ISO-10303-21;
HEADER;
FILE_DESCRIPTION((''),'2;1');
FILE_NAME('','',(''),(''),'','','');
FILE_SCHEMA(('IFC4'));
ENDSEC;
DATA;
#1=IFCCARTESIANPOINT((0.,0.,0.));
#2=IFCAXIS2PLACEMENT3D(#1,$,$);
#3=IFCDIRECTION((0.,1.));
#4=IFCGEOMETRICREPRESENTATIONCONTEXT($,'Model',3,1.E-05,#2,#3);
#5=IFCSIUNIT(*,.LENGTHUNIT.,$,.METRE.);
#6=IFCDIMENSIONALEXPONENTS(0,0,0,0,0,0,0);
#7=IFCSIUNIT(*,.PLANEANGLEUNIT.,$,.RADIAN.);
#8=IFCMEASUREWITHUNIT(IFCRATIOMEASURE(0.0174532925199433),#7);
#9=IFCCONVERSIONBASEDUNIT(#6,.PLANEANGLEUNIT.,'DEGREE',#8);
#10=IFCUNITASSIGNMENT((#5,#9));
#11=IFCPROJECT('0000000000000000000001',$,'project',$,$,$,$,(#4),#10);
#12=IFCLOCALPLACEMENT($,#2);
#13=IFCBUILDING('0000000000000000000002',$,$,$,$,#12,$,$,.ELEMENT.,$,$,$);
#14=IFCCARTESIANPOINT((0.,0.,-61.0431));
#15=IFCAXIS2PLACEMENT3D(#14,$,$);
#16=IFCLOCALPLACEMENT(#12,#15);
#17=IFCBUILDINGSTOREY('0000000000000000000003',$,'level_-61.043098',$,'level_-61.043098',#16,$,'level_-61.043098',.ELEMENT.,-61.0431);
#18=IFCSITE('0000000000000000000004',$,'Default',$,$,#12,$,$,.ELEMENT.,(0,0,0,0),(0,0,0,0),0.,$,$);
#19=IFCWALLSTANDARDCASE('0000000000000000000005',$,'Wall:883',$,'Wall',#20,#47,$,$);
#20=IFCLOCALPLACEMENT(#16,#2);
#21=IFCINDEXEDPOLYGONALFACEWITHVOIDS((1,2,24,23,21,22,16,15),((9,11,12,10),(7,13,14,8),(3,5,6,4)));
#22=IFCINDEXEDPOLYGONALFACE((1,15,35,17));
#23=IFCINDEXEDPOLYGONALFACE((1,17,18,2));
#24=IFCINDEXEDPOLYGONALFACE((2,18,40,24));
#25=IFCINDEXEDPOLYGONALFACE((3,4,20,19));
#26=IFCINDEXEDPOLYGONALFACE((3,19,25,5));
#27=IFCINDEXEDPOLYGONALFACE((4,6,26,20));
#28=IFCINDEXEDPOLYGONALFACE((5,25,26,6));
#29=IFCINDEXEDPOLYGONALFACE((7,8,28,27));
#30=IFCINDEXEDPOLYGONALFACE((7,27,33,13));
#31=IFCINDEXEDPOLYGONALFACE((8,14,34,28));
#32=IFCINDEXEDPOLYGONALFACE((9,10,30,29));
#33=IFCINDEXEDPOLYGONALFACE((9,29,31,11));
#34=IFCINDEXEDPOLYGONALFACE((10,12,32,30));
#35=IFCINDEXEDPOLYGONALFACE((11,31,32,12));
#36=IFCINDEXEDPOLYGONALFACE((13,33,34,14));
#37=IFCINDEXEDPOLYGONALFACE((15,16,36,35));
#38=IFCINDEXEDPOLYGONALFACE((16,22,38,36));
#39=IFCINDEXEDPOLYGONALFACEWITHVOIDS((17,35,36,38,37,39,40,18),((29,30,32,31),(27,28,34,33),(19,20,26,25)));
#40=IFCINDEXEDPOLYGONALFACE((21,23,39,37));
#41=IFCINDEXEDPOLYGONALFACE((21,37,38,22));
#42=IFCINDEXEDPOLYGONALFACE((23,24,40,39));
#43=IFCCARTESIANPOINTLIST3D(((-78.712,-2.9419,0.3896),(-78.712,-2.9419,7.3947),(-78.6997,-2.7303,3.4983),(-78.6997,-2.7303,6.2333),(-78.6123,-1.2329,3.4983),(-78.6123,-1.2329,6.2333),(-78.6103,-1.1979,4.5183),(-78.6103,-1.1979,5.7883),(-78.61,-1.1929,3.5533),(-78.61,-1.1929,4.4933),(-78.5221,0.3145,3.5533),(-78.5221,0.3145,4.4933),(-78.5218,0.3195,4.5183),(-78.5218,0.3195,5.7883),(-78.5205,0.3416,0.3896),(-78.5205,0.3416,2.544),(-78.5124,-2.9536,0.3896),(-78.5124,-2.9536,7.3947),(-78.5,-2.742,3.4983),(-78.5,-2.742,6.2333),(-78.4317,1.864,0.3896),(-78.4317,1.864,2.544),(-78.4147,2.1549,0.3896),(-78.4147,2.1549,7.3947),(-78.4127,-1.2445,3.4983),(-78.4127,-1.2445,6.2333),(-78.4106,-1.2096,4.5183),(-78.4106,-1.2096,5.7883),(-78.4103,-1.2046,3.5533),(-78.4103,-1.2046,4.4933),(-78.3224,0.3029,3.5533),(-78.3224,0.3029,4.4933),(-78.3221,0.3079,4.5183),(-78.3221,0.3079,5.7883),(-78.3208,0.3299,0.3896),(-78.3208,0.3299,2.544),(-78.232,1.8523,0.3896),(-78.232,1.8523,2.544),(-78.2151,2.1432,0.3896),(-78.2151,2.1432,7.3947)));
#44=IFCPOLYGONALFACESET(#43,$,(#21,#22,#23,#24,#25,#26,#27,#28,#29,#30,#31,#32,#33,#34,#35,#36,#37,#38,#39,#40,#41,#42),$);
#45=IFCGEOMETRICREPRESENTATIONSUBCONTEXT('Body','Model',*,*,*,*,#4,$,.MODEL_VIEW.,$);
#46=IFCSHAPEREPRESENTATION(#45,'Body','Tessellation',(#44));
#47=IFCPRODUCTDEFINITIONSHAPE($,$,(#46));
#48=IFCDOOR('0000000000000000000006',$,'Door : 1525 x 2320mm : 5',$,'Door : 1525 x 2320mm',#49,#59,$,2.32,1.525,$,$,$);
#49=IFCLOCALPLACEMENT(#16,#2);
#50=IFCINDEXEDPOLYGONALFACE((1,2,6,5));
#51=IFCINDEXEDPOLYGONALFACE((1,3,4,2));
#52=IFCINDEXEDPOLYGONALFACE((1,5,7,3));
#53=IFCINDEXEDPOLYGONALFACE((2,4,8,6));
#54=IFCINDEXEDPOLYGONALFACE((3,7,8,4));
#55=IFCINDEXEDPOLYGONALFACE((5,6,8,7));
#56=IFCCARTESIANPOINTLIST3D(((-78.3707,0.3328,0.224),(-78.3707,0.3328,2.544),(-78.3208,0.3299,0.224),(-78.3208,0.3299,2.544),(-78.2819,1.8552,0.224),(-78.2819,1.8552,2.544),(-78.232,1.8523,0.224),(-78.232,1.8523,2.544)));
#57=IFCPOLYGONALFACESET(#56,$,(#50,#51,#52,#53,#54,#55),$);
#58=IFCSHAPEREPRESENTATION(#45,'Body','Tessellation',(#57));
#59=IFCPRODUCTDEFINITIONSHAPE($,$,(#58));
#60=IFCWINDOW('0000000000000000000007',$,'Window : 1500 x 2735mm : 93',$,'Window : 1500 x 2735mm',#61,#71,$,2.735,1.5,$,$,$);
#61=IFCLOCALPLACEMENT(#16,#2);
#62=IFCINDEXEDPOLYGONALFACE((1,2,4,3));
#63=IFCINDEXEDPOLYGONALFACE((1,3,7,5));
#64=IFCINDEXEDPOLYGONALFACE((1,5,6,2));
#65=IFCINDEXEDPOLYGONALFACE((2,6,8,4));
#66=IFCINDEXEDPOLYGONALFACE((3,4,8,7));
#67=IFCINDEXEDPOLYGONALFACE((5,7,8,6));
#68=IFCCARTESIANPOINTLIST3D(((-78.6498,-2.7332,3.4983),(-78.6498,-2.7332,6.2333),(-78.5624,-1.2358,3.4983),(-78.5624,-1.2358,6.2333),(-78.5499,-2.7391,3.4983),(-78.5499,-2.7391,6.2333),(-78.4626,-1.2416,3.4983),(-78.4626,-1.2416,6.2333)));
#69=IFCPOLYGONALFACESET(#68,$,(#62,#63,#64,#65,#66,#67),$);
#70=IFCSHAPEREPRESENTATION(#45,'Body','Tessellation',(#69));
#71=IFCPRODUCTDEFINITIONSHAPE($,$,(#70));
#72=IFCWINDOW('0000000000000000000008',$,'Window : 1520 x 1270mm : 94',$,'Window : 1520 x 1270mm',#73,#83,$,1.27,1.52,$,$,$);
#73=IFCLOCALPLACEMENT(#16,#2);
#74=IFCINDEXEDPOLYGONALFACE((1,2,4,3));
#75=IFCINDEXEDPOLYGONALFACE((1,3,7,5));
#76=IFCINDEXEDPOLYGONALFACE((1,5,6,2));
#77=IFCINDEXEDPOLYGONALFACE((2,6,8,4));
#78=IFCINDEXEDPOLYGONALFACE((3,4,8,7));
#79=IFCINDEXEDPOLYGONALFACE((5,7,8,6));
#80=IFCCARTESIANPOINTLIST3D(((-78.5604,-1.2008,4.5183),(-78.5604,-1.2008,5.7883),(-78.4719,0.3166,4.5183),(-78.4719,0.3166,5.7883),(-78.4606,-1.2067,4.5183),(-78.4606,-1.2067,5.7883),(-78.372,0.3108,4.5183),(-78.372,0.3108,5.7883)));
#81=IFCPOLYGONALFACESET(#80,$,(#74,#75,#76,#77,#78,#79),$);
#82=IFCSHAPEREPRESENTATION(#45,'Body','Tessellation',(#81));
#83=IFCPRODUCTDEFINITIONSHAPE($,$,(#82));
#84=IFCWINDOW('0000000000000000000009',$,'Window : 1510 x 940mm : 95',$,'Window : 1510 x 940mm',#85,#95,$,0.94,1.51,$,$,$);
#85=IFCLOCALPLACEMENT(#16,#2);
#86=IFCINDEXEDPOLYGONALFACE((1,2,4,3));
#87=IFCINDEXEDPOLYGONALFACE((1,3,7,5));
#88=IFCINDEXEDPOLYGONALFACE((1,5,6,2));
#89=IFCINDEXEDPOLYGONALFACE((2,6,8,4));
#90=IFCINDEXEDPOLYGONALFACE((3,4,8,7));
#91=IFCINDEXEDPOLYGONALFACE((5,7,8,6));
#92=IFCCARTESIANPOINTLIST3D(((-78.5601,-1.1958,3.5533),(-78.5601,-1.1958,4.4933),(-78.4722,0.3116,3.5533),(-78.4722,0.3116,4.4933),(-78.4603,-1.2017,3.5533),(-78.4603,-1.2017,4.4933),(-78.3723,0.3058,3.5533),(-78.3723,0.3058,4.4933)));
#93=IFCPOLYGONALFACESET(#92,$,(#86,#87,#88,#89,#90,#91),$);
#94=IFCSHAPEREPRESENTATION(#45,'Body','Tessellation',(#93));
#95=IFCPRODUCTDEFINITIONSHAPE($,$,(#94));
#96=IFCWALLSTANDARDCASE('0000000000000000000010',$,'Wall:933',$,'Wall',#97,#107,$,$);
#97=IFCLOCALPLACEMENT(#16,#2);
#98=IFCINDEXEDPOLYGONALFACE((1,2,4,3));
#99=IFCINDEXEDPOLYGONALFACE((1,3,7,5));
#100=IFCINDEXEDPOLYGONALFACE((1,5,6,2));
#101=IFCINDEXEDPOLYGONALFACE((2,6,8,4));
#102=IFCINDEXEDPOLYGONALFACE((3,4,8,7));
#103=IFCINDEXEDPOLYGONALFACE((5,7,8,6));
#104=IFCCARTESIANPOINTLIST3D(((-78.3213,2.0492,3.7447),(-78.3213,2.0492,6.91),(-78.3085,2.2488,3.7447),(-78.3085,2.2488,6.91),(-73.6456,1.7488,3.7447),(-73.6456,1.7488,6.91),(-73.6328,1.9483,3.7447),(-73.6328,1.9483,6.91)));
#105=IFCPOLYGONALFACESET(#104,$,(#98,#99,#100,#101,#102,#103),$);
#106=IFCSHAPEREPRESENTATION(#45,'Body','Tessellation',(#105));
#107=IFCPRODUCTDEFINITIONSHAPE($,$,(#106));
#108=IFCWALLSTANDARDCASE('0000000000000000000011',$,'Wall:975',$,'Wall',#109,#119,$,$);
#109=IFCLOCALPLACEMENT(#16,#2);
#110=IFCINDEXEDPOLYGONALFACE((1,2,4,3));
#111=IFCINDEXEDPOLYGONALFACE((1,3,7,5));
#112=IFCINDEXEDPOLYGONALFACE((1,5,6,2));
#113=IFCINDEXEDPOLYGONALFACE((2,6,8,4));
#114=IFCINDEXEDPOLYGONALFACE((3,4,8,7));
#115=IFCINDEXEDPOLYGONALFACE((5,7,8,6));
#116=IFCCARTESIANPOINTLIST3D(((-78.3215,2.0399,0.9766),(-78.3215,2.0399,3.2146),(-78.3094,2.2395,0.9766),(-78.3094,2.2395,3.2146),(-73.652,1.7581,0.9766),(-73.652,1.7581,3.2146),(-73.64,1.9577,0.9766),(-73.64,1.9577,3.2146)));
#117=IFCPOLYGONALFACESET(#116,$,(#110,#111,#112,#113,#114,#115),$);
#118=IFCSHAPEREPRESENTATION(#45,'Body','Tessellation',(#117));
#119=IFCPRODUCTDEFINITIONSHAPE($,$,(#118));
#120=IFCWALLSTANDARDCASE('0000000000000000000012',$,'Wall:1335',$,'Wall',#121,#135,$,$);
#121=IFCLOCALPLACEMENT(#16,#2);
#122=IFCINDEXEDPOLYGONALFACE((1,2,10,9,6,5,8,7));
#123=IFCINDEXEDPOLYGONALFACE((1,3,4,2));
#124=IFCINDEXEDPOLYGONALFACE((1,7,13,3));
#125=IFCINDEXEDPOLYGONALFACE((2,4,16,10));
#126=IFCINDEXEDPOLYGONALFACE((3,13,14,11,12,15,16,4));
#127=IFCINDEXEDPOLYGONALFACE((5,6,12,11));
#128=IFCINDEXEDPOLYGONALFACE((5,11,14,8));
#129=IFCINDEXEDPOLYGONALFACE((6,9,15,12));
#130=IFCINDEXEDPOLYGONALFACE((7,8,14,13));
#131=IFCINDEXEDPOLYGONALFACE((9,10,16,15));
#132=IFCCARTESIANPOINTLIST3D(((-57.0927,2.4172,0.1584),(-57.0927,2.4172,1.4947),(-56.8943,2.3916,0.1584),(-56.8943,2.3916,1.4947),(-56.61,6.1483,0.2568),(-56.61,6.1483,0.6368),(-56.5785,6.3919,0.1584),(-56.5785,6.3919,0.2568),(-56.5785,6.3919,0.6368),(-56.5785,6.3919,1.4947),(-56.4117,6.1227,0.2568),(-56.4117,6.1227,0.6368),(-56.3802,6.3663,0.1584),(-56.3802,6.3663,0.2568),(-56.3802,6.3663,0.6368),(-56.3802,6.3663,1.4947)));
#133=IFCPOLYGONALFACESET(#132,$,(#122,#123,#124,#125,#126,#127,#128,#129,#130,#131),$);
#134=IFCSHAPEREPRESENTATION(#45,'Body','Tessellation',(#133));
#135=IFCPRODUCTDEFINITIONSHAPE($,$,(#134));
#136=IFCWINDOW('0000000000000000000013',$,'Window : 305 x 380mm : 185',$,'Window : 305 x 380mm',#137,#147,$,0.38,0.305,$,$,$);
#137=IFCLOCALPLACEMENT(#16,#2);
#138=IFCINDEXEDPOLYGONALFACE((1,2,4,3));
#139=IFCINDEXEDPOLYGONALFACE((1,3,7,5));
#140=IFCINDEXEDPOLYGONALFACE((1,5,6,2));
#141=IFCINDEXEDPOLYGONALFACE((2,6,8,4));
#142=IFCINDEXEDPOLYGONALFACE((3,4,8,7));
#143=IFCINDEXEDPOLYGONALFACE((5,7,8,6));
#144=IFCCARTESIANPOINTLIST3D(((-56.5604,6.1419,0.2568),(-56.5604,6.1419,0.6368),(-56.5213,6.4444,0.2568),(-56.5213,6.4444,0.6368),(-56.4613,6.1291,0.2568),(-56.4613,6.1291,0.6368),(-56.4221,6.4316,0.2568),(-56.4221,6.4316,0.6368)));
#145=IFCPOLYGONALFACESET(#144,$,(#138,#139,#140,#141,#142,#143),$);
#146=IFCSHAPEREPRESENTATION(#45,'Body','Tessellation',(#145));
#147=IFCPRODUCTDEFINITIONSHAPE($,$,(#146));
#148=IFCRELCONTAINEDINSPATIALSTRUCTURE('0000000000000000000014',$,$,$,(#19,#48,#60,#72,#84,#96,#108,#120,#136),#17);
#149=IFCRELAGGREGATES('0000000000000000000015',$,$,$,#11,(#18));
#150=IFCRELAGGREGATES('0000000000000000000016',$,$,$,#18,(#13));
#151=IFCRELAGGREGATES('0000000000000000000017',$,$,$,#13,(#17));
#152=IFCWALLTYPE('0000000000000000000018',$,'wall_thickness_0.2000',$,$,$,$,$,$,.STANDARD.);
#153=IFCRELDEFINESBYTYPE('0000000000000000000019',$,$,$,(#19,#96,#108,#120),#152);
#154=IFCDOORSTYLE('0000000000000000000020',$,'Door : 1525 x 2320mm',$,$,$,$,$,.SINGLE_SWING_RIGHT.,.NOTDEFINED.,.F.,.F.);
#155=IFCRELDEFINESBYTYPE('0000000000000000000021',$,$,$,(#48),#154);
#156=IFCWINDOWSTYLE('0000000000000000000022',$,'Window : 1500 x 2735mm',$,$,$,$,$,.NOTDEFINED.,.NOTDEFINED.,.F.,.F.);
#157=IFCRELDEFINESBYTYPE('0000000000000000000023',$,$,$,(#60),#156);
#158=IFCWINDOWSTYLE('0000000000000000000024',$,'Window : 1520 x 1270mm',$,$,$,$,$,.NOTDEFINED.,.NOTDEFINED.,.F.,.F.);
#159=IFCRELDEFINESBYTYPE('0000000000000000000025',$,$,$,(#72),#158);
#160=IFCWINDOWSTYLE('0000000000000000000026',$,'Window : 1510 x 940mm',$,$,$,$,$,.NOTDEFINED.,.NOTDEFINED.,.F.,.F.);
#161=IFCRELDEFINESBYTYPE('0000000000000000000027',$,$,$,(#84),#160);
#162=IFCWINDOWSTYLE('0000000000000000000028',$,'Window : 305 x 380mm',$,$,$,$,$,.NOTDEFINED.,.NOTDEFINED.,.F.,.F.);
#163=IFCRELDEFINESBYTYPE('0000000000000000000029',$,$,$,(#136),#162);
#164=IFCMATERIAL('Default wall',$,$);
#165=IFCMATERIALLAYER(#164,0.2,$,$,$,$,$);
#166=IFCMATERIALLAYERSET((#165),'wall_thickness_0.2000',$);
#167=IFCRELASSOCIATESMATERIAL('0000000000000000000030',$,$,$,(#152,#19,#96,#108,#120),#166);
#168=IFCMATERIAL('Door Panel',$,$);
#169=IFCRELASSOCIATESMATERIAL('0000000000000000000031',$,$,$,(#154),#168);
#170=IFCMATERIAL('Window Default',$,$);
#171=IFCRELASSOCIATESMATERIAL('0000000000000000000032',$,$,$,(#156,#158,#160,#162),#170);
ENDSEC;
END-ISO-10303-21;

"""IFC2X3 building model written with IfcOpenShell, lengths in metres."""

from ifc_helpers import new_model, entity, si_unit, converted_unit, direction, frame, frame_2d, origin, origin_2d_with_axis, place, context, subcontext, project, spatial, polyline, rectangle, outline, extrude, source, transform, mapped, material, layer, layer_set, layer_usage, type_object, type_shapes, element, fill, save


model = new_model("IFC2X3")

# Units and contexts
model_context = context("Model", 3, precision=1e-05, world=origin(), true_north=direction((0.0, 1.0)))
body_context = subcontext(model_context, "Body", "Model", "MODEL_VIEW")
ifc_project = project(units=[si_unit("LENGTHUNIT", "METRE"), converted_unit("PLANEANGLEUNIT", "DEGREE", entity("IfcRatioMeasure", 0.0174532925199433), si_unit("PLANEANGLEUNIT", "RADIAN"), dimensions=[0, 0, 0, 0, 0, 0, 0])], contexts=[model_context])

# Site, building, storey
placement_1 = place(None, origin())
site = spatial("IfcSite", under=ifc_project, at=placement_1, Name="Default", CompositionType="ELEMENT", RefLatitude=(0, 0, 0, 0), RefLongitude=(0, 0, 0, 0), RefElevation=0.0)
building = spatial("IfcBuilding", under=site, at=placement_1, CompositionType="ELEMENT")
storey_placement = place(placement_1, frame((0.0, 0.0, -61.0431)))
storey = spatial("IfcBuildingStorey", under=building, at=storey_placement, Name="level_-61.043098", ObjectType="level_-61.043098", LongName="level_-61.043098", CompositionType="ELEMENT", Elevation=-61.0431)

# Shared definitions
ifc_material_1 = material(Name="Default wall")
ifc_layer = layer(ifc_material_1, 0.2)
ifc_layer_set = layer_set([ifc_layer], Name="wall_thickness_0.2000")
ifc_layer_usage = layer_usage(ifc_layer_set, "AXIS2", "POSITIVE", -0.1)
wall_type = type_object("IfcWallType", Name="wall_thickness_0.2000", PredefinedType="STANDARD", material=ifc_layer_set)

# Shared definitions
ifc_material_2 = material(Name="Window Default")

# Wall, openings, door, windows
placement_2 = place(placement_1, frame((0.0, 0.0, -60.6535)))
wall_1_placement = place(placement_2, frame((-78.3149, 2.149, 0.0), z_axis=(0.0, 0.0, 1.0), x_axis=(-0.058234, -0.998303, 0.0)))
wall_1 = element("IfcWallStandardCase", 1, at=wall_1_placement, inside=storey, type_object=wall_type, material=ifc_layer_usage, Name="Wall:883", ObjectType="Wall", context=body_context, shape_type="SweptSolid", body=[
    extrude(outline(polyline([(5.1054, -0.1), (5.1054, 0.1), (0.0, 0.1), (0.0, -0.1), (5.1054, -0.1)])), origin(), (0.0, 0.0, 1.0), 7.0051),
])
opening_1_placement = place(wall_1_placement, frame((0.2914, -0.1, -0.1656)))
opening_1 = element("IfcOpeningElement", 2, at=opening_1_placement, cuts=wall_1, ObjectType="Opening", context=body_context, shape_type="SweptSolid", body=[
    extrude(rectangle(XDim=1.525, YDim=2.32, at=frame_2d((1.16, 0.7625), x_axis=(0.0, 1.0))), frame((0.0, 0.0, 0.0), z_axis=(0.0, 1.0, 0.0), x_axis=(0.0, 0.0, 1.0)), (0.0, 0.0, 1.0), 0.2),
])
opening_2_placement = place(wall_1_placement, frame((3.3935, -0.1, 3.1088)))
opening_2 = element("IfcOpeningElement", 3, at=opening_2_placement, cuts=wall_1, ObjectType="Opening", context=body_context, shape_type="SweptSolid", body=[
    extrude(rectangle(XDim=1.5, YDim=2.735, at=frame_2d((1.3675, 0.75), x_axis=(0.0, 1.0))), frame((0.0, 0.0, 0.0), z_axis=(0.0, 1.0, 0.0), x_axis=(0.0, 0.0, 1.0)), (0.0, 0.0, 1.0), 0.2),
])
opening_3_placement = place(wall_1_placement, frame((1.8385, -0.1, 4.1288)))
opening_3 = element("IfcOpeningElement", 4, at=opening_3_placement, cuts=wall_1, ObjectType="Opening", context=body_context, shape_type="SweptSolid", body=[
    extrude(rectangle(XDim=1.52, YDim=1.27, at=frame_2d((0.635, 0.76), x_axis=(0.0, 1.0))), frame((0.0, 0.0, 0.0), z_axis=(0.0, 1.0, 0.0), x_axis=(0.0, 0.0, 1.0)), (0.0, 0.0, 1.0), 0.2),
])
opening_4_placement = place(wall_1_placement, frame((1.8435, -0.1, 3.1638)))
opening_4 = element("IfcOpeningElement", 5, at=opening_4_placement, cuts=wall_1, ObjectType="Opening", context=body_context, shape_type="SweptSolid", body=[
    extrude(rectangle(XDim=1.51, YDim=0.94, at=frame_2d((0.47, 0.755), x_axis=(0.0, 1.0))), frame((0.0, 0.0, 0.0), z_axis=(0.0, 1.0, 0.0), x_axis=(0.0, 0.0, 1.0)), (0.0, 0.0, 1.0), 0.2),
])
ifc_material_3 = material(Name="Door Panel")
door_style = type_object("IfcDoorStyle", Name="Door : 1525 x 2320mm", ConstructionType="NOTDEFINED", OperationType="SINGLE_SWING_RIGHT", ParameterTakesPrecedence=False, Sizeable=False, material=ifc_material_3)
shared_shape_1 = source(origin(), body_context, "Body", "SweptSolid", [
    extrude(rectangle(XDim=0.05, YDim=1.525, at=origin_2d_with_axis()), frame((0.7625, 0.175, 0.0), z_axis=(0.0, 0.0, 1.0), x_axis=(0.0, 1.0, 0.0)), (0.0, 0.0, 1.0), 2.32),
])
type_shapes(door_style, [shared_shape_1])
door_placement = place(opening_1_placement, origin())
door = element("IfcDoor", 6, at=door_placement, inside=storey, type_object=door_style, Name="Door : 1525 x 2320mm : 5", ObjectType="Door : 1525 x 2320mm", OverallHeight=2.32, OverallWidth=1.525, context=body_context, shape_type="MappedRepresentation", body=[
    mapped(shared_shape_1, transform((0.0, 0.0, 0.0), scale=1.0)),
])
fill(opening_1, door)
window_style_1 = type_object("IfcWindowStyle", Name="Window : 1500 x 2735mm", ConstructionType="NOTDEFINED", OperationType="NOTDEFINED", ParameterTakesPrecedence=False, Sizeable=False, material=ifc_material_2)
shared_shape_2 = source(origin(), body_context, "Body", "SweptSolid", [
    extrude(rectangle(XDim=0.1, YDim=1.5, at=origin_2d_with_axis()), frame((0.75, 0.1, 0.0), z_axis=(0.0, 0.0, 1.0), x_axis=(0.0, 1.0, 0.0)), (0.0, 0.0, 1.0), 2.735),
])
type_shapes(window_style_1, [shared_shape_2])
window_1_placement = place(opening_2_placement, origin())
window_1 = element("IfcWindow", 7, at=window_1_placement, inside=storey, type_object=window_style_1, Name="Window : 1500 x 2735mm : 93", ObjectType="Window : 1500 x 2735mm", OverallHeight=2.735, OverallWidth=1.5, context=body_context, shape_type="MappedRepresentation", body=[
    mapped(shared_shape_2, transform((0.0, 0.0, 0.0), scale=1.0)),
])
fill(opening_2, window_1)
window_style_2 = type_object("IfcWindowStyle", Name="Window : 1520 x 1270mm", ConstructionType="NOTDEFINED", OperationType="NOTDEFINED", ParameterTakesPrecedence=False, Sizeable=False, material=ifc_material_2)
shared_shape_3 = source(origin(), body_context, "Body", "SweptSolid", [
    extrude(rectangle(XDim=0.1, YDim=1.52, at=origin_2d_with_axis()), frame((0.76, 0.1, 0.0), z_axis=(0.0, 0.0, 1.0), x_axis=(0.0, 1.0, 0.0)), (0.0, 0.0, 1.0), 1.27),
])
type_shapes(window_style_2, [shared_shape_3])
window_2_placement = place(opening_3_placement, origin())
window_2 = element("IfcWindow", 8, at=window_2_placement, inside=storey, type_object=window_style_2, Name="Window : 1520 x 1270mm : 94", ObjectType="Window : 1520 x 1270mm", OverallHeight=1.27, OverallWidth=1.52, context=body_context, shape_type="MappedRepresentation", body=[
    mapped(shared_shape_3, transform((0.0, 0.0, 0.0), scale=1.0)),
])
fill(opening_3, window_2)
window_style_3 = type_object("IfcWindowStyle", Name="Window : 1510 x 940mm", ConstructionType="NOTDEFINED", OperationType="NOTDEFINED", ParameterTakesPrecedence=False, Sizeable=False, material=ifc_material_2)
shared_shape_4 = source(origin(), body_context, "Body", "SweptSolid", [
    extrude(rectangle(XDim=0.1, YDim=1.51, at=origin_2d_with_axis()), frame((0.755, 0.1, 0.0), z_axis=(0.0, 0.0, 1.0), x_axis=(0.0, 1.0, 0.0)), (0.0, 0.0, 1.0), 0.94),
])
type_shapes(window_style_3, [shared_shape_4])
window_3_placement = place(opening_4_placement, origin())
window_3 = element("IfcWindow", 9, at=window_3_placement, inside=storey, type_object=window_style_3, Name="Window : 1510 x 940mm : 95", ObjectType="Window : 1510 x 940mm", OverallHeight=0.94, OverallWidth=1.51, context=body_context, shape_type="MappedRepresentation", body=[
    mapped(shared_shape_4, transform((0.0, 0.0, 0.0), scale=1.0)),
])
fill(opening_4, window_3)

# Walls
placement_3 = place(placement_1, frame((0.0, 0.0, -57.2984)))
wall_2_placement = place(placement_3, frame((-78.3149, 2.149, 0.0), z_axis=(0.0, 0.0, 1.0), x_axis=(0.997941, -0.064135, 0.0)))
element("IfcWallStandardCase", 10, at=wall_2_placement, inside=storey, type_object=wall_type, material=ifc_layer_usage, Name="Wall:933", ObjectType="Wall", context=body_context, shape_type="SweptSolid", body=[
    extrude(outline(polyline([(4.6853, -0.1), (4.6853, 0.1), (0.0, 0.1), (0.0, -0.1), (4.6853, -0.1)])), origin(), (0.0, 0.0, 1.0), 3.1652),
])
placement_4 = place(placement_1, frame((0.0, 0.0, -60.0665)))
wall_3_placement = place(placement_4, frame((-78.3154, 2.1397, 0.0), z_axis=(0.0, 0.0, 1.0), x_axis=(0.998184, -0.060232, 0.0)))
element("IfcWallStandardCase", 11, at=wall_3_placement, inside=storey, type_object=wall_type, material=ifc_layer_usage, Name="Wall:975", ObjectType="Wall", context=body_context, shape_type="SweptSolid", body=[
    extrude(outline(polyline([(4.6779, -0.1), (4.6779, 0.1), (0.0, 0.1), (0.0, -0.1), (4.6779, -0.1)])), origin(), (0.0, 0.0, 1.0), 2.238),
])

# Wall, opening, window
placement_5 = place(placement_1, frame((0.0, 0.0, -60.8847)))
wall_4_placement = place(placement_5, frame((-56.9935, 2.4044, 0.0), z_axis=(0.0, 0.0, 1.0), x_axis=(0.128284, 0.991737, 0.0)))
wall_4 = element("IfcWallStandardCase", 12, at=wall_4_placement, inside=storey, type_object=wall_type, material=ifc_layer_usage, Name="Wall:1335", ObjectType="Wall", context=body_context, shape_type="SweptSolid", body=[
    extrude(outline(polyline([(4.0078, -0.1), (4.0078, 0.1), (0.0, 0.1), (0.0, -0.1), (4.0078, -0.1)])), origin(), (0.0, 0.0, 1.0), 1.3363),
])
opening_5_placement = place(wall_4_placement, frame((3.7622, -0.1, 0.0984)))
opening_5 = element("IfcOpeningElement", 13, at=opening_5_placement, cuts=wall_4, ObjectType="Opening", context=body_context, shape_type="SweptSolid", body=[
    extrude(rectangle(XDim=0.305, YDim=0.38, at=frame_2d((0.19, 0.1525), x_axis=(0.0, 1.0))), frame((0.0, 0.0, 0.0), z_axis=(0.0, 1.0, 0.0), x_axis=(0.0, 0.0, 1.0)), (0.0, 0.0, 1.0), 0.2),
])
window_style_4 = type_object("IfcWindowStyle", Name="Window : 305 x 380mm", ConstructionType="NOTDEFINED", OperationType="NOTDEFINED", ParameterTakesPrecedence=False, Sizeable=False, material=ifc_material_2)
shared_shape_5 = source(origin(), body_context, "Body", "SweptSolid", [
    extrude(rectangle(XDim=0.1, YDim=0.305, at=origin_2d_with_axis()), frame((0.1525, 0.1, 0.0), z_axis=(0.0, 0.0, 1.0), x_axis=(0.0, 1.0, 0.0)), (0.0, 0.0, 1.0), 0.38),
])
type_shapes(window_style_4, [shared_shape_5])
window_4_placement = place(opening_5_placement, origin())
window_4 = element("IfcWindow", 14, at=window_4_placement, inside=storey, type_object=window_style_4, Name="Window : 305 x 380mm : 185", ObjectType="Window : 305 x 380mm", OverallHeight=0.38, OverallWidth=0.305, context=body_context, shape_type="MappedRepresentation", body=[
    mapped(shared_shape_5, transform((0.0, 0.0, 0.0), scale=1.0)),
])
fill(opening_5, window_4)

save(model, "model.ifc")
